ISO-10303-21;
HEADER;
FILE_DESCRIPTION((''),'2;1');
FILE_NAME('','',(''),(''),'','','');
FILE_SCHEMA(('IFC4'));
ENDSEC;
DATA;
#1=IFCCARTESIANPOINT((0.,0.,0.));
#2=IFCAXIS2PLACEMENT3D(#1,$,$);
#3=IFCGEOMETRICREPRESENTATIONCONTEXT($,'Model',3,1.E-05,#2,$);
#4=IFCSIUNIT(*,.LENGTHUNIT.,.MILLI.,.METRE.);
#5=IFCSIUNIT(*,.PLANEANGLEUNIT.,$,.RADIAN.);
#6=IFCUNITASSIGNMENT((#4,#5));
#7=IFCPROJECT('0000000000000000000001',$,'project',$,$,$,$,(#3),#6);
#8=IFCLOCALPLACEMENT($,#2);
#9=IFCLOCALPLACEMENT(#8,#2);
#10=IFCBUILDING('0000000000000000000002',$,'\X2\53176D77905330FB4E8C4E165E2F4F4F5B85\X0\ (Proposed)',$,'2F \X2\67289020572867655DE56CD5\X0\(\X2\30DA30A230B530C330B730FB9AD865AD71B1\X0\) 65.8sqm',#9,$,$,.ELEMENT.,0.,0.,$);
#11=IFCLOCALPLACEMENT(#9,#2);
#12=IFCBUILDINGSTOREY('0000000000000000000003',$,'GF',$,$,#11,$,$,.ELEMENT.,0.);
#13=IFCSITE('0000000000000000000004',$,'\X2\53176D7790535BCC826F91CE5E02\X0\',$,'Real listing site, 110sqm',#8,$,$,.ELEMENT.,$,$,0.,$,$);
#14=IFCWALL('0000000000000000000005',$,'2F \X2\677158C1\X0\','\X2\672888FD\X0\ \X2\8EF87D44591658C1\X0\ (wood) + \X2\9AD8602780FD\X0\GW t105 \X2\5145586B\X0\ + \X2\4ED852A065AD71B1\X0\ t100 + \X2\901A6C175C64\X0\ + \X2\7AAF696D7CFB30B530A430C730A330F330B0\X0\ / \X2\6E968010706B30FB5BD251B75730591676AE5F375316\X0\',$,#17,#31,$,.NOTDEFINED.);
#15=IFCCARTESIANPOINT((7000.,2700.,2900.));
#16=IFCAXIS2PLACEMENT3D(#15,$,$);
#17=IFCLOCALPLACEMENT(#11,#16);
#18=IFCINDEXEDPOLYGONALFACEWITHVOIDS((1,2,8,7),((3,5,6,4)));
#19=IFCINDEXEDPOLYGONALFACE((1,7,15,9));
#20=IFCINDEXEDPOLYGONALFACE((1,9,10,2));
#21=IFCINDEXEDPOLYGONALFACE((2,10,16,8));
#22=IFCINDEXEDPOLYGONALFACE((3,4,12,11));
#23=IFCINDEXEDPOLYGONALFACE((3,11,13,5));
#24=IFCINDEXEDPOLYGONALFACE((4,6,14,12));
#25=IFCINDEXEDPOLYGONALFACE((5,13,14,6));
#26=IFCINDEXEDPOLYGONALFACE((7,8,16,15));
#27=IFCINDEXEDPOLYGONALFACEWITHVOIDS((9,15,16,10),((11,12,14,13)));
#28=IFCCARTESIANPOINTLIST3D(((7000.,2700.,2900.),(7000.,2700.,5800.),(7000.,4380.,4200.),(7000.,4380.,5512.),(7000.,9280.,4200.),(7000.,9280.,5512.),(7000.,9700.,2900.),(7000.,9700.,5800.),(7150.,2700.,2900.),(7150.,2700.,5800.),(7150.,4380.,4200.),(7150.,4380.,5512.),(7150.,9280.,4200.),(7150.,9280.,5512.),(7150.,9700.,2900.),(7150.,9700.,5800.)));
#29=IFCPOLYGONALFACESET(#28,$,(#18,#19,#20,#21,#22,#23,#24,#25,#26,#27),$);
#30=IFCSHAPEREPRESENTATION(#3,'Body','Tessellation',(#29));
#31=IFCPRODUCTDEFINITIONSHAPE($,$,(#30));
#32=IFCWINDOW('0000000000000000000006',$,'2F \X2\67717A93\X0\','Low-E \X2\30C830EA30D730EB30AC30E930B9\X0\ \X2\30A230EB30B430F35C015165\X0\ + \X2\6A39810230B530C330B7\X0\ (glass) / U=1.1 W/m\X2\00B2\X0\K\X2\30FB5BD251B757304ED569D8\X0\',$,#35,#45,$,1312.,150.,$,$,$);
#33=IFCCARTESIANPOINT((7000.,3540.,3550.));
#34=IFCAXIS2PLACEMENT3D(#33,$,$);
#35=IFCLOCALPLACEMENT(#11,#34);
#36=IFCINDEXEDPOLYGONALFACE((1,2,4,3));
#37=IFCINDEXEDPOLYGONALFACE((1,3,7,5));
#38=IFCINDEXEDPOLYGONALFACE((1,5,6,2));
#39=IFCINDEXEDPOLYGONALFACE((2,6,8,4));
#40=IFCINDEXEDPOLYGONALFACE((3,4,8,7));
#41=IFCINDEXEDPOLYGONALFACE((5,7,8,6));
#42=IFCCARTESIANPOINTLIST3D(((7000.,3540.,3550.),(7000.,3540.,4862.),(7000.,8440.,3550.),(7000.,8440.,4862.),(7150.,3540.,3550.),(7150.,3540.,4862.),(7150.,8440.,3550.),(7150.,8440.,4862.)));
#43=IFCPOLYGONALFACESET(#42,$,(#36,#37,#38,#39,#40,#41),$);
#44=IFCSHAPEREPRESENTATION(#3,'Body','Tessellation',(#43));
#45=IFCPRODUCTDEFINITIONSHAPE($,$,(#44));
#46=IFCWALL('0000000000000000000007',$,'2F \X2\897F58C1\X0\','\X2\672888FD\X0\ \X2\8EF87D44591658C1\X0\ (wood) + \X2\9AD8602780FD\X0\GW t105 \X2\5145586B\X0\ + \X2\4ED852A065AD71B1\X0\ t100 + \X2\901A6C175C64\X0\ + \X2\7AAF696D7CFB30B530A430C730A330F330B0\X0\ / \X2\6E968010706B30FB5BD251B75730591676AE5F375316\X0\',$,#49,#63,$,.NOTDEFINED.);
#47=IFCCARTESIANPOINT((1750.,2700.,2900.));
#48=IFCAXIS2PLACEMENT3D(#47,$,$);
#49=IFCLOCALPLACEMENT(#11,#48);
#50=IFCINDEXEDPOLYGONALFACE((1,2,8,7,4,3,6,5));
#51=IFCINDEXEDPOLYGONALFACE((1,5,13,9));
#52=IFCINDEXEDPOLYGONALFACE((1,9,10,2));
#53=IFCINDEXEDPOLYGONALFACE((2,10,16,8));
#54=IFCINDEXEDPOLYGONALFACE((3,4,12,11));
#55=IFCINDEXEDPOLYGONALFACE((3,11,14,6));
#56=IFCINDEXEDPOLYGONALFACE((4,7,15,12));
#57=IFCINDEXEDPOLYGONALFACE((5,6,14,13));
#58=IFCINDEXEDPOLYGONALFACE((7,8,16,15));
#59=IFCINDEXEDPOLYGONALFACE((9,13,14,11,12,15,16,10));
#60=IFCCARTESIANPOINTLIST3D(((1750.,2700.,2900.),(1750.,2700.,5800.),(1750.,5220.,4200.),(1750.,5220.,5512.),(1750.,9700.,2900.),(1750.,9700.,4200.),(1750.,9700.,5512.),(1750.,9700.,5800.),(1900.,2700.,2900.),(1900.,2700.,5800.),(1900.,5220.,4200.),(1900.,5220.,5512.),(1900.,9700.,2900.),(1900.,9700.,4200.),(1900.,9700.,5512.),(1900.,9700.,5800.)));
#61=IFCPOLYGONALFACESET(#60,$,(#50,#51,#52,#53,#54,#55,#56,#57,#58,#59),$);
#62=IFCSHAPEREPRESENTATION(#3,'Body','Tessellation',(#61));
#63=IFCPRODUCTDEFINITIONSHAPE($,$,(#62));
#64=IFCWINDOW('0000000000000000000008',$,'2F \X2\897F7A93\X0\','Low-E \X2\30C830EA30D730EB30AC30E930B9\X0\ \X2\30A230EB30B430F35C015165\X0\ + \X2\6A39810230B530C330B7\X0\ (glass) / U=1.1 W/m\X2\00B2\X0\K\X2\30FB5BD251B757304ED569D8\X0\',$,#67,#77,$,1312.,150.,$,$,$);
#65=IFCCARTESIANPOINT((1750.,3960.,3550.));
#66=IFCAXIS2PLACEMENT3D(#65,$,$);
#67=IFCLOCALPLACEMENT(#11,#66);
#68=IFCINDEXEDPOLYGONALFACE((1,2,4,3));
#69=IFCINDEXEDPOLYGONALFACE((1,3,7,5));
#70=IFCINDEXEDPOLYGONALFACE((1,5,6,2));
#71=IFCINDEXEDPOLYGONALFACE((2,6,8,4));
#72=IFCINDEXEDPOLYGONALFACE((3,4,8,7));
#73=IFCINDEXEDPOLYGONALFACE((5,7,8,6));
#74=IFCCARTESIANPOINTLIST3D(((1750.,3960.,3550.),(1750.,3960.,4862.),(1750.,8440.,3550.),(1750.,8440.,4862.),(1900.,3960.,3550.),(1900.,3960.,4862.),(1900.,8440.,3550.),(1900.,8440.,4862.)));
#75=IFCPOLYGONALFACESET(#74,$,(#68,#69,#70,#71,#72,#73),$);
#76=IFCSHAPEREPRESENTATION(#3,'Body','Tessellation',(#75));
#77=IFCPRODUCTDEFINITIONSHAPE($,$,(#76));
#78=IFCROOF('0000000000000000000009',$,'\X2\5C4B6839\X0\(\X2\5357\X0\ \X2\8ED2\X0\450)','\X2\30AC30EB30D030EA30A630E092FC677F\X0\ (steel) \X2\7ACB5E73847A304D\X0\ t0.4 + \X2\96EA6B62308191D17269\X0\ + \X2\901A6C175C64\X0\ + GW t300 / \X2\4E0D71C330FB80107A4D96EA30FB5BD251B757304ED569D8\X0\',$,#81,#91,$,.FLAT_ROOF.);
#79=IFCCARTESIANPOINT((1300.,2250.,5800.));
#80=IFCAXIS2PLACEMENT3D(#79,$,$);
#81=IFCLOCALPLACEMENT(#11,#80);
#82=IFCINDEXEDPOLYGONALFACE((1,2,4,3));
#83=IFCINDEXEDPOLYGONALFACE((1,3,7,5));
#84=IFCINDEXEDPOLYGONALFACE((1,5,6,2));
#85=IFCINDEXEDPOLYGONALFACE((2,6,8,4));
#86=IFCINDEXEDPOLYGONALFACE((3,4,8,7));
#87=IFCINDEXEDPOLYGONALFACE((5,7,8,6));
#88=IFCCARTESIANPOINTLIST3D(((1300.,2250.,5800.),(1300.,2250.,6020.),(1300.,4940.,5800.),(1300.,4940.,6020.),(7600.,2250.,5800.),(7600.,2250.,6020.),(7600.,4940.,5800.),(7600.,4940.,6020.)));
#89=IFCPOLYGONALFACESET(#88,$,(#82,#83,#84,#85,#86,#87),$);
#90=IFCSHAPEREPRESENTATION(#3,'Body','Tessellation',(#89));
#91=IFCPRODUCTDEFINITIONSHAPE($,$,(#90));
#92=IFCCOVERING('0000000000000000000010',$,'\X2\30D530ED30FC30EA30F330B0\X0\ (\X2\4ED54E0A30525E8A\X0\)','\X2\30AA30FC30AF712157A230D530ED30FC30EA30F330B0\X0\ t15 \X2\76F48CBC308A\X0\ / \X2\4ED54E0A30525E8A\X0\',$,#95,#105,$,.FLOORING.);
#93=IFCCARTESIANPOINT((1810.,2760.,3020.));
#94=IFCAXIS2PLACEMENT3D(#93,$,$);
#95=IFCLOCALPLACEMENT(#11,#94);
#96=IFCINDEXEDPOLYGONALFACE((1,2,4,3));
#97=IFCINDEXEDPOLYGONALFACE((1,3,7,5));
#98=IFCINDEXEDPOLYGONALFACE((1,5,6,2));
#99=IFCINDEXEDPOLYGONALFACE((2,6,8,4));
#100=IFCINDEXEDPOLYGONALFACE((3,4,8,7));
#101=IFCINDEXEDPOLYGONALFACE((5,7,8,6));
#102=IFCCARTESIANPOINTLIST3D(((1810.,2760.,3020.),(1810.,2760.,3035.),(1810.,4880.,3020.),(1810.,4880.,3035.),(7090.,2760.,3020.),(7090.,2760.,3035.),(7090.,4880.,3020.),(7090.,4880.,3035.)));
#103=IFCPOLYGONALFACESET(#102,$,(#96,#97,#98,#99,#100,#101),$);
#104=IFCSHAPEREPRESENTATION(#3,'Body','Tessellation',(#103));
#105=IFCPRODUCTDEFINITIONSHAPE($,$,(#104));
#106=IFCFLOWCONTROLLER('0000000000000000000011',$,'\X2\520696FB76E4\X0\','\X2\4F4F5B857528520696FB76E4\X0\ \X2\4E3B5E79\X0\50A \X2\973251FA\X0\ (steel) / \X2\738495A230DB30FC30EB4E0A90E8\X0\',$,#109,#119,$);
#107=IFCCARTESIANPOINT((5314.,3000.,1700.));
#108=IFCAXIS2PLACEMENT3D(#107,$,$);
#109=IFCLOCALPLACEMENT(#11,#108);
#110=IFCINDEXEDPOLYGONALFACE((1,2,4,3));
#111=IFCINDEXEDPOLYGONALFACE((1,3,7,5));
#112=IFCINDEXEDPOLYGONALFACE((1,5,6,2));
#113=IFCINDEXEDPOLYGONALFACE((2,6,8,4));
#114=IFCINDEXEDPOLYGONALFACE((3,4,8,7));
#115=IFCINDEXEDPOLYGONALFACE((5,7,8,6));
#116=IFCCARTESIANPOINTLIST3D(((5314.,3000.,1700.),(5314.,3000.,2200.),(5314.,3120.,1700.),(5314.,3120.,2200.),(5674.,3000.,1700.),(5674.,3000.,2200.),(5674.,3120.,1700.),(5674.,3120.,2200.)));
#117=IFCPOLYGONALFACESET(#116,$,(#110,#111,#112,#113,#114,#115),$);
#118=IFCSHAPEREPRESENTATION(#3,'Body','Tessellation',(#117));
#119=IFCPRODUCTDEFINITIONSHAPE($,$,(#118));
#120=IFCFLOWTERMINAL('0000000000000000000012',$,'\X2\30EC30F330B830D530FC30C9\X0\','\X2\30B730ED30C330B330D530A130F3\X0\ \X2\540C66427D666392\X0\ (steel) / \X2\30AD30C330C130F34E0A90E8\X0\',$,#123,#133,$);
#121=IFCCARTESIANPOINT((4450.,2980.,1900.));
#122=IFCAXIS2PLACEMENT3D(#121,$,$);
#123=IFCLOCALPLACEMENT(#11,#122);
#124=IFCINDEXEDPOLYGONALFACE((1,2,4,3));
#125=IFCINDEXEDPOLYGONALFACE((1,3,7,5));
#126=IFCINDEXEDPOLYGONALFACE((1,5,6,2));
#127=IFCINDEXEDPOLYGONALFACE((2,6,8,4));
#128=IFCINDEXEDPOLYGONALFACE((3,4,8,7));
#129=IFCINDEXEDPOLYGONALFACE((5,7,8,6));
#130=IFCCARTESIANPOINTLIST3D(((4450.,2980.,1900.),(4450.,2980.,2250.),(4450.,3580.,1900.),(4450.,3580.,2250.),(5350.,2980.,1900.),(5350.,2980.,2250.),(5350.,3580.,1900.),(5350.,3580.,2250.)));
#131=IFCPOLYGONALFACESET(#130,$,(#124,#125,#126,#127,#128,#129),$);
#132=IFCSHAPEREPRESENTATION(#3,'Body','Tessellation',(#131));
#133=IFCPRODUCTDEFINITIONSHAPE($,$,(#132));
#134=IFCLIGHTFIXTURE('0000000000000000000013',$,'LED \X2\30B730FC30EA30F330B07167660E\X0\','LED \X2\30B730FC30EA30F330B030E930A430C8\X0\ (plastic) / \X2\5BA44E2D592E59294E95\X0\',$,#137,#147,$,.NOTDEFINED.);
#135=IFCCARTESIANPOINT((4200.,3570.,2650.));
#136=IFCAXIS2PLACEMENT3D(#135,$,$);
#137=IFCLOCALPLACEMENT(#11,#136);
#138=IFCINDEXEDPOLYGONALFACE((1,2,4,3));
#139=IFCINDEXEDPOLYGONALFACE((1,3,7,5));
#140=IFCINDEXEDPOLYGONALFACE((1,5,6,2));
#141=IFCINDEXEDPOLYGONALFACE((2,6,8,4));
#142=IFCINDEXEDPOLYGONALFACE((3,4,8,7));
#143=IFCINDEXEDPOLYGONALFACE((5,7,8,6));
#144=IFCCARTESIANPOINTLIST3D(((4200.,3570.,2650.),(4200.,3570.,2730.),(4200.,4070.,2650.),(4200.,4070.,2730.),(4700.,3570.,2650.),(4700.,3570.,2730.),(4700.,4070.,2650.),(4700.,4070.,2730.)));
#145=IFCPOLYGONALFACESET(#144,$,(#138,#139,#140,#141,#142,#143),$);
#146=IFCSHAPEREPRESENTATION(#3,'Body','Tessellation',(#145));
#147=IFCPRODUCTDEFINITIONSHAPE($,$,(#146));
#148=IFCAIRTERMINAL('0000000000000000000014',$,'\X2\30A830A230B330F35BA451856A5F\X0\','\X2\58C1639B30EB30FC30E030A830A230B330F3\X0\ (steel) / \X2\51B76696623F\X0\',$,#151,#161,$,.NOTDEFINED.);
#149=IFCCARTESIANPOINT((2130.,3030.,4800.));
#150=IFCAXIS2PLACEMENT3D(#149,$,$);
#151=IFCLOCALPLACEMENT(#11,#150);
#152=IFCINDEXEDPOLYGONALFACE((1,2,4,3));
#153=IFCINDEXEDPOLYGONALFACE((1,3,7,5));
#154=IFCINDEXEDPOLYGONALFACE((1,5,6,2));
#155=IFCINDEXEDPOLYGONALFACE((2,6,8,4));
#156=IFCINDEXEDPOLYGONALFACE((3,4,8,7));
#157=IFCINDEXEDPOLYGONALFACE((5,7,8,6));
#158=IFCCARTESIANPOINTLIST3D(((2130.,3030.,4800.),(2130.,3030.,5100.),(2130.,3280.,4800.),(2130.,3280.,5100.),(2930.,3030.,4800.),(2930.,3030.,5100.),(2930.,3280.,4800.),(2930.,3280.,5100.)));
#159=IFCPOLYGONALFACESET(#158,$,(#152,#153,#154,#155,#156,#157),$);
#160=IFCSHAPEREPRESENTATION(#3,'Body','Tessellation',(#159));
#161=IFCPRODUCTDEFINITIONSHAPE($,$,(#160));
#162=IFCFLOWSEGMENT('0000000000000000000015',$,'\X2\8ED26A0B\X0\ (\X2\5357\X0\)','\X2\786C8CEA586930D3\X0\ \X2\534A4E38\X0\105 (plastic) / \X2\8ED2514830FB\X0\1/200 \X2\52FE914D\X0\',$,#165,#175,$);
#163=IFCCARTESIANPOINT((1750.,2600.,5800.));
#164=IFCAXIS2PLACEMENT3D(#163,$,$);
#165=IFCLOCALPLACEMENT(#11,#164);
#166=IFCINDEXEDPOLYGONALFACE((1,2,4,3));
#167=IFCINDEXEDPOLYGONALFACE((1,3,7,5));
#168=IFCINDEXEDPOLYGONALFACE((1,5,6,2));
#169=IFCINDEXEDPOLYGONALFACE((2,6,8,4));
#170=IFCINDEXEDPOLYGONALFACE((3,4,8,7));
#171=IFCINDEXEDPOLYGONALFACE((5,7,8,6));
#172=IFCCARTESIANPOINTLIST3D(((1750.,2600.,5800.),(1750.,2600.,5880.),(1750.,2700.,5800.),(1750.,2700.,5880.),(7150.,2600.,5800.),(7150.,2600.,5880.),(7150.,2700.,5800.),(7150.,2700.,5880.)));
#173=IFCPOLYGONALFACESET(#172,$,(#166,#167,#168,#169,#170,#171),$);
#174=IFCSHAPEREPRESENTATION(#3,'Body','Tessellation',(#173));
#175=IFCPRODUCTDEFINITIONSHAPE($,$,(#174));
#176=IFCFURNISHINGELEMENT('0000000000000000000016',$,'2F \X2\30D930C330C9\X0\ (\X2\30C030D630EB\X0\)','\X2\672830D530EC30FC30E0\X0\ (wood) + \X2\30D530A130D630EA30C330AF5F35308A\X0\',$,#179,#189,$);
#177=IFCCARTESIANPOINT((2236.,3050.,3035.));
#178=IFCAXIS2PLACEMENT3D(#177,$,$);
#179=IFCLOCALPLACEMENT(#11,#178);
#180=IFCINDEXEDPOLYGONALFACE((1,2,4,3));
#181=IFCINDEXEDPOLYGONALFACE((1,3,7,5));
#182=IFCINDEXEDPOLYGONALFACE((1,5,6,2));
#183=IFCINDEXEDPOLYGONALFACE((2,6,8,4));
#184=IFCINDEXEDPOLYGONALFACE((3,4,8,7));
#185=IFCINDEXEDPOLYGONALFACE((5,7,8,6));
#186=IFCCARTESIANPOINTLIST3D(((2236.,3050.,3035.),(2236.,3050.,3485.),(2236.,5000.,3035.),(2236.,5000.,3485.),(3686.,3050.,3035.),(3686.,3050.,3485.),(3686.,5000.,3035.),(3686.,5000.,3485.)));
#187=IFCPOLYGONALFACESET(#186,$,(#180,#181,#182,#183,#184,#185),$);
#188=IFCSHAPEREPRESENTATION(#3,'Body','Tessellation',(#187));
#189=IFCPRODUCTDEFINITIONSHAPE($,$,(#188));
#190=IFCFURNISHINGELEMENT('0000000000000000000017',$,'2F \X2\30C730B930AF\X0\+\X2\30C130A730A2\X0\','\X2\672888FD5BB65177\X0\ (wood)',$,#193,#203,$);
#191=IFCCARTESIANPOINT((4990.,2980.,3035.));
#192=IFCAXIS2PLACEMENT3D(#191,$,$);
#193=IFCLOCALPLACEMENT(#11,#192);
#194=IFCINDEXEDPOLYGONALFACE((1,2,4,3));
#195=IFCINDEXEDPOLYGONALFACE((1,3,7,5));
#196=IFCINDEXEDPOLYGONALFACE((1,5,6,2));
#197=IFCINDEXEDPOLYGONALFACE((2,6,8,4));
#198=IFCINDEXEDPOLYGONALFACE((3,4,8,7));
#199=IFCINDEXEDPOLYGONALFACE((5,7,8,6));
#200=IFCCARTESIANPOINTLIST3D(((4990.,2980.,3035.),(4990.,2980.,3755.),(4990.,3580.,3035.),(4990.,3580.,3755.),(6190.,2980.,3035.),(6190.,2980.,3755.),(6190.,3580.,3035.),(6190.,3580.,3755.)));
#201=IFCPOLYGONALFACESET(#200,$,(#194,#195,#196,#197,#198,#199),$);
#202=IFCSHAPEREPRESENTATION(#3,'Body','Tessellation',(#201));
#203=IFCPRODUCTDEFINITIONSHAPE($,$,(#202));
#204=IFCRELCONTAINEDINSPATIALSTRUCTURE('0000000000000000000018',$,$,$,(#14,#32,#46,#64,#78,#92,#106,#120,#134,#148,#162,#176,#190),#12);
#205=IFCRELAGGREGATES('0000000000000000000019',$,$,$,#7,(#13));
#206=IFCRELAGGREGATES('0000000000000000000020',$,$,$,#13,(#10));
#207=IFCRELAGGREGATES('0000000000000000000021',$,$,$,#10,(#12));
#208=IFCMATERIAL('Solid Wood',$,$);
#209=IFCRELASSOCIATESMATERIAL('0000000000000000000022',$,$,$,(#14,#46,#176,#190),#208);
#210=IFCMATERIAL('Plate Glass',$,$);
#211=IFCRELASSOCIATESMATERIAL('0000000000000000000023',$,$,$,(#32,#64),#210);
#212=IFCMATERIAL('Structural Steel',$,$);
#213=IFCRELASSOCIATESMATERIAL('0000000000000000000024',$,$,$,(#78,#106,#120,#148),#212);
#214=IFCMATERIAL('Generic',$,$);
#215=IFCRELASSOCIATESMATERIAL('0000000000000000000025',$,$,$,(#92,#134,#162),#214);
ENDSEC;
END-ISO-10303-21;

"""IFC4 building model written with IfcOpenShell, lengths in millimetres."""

from ifc_helpers import new_model, si_unit, frame, frame_2d, origin, place, context, project, spatial, rectangle, extrude, material, element, fill, save


model = new_model("IFC4")

# Units and contexts
model_context = context("Model", 3, precision=1e-05, world=origin())
ifc_project = project(units=[si_unit("LENGTHUNIT", "METRE", prefix="MILLI"), si_unit("PLANEANGLEUNIT", "RADIAN")], contexts=[model_context])

# Site, building, storey
site_placement = place(None, origin())
site = spatial("IfcSite", under=ifc_project, at=site_placement, Name="北海道富良野市", ObjectType="Real listing site, 110sqm", CompositionType="ELEMENT", RefElevation=0.0)
building_placement = place(site_placement, origin())
building = spatial("IfcBuilding", under=site, at=building_placement, Name="北海道・二世帯住宅 (Proposed)", ObjectType="2F 木造在来工法(ペアサッシ・高断熱) 65.8sqm", CompositionType="ELEMENT", ElevationOfRefHeight=0.0, ElevationOfTerrain=0.0)
storey_placement = place(building_placement, origin())
storey = spatial("IfcBuildingStorey", under=building, at=storey_placement, Name="GF", CompositionType="ELEMENT", Elevation=0.0)

# Shared definitions
ifc_material_1 = material(Name="Solid Wood")

# Shared definitions
ifc_material_2 = material(Name="Plate Glass")

# Walls, openings, windows
wall_1_placement = place(storey_placement, frame((7000.0, 2700.0, 2900.0)))
wall_1 = element("IfcWall", 1, at=wall_1_placement, inside=storey, material=ifc_material_1, Name="2F 東壁", Description="木製 軸組外壁 (wood) + 高性能GW t105 充填 + 付加断熱 t100 + 通気層 + 窯業系サイディング / 準耐火・寒冷地外皮強化", PredefinedType="NOTDEFINED", context=model_context, shape_type="SweptSolid", body=[
    extrude(rectangle(XDim=150.0, YDim=7000.0, at=frame_2d((75.0, 3500.0))), frame((7000.0, 2700.0, 2900.0)), (0.0, 0.0, 1.0), 2900.0),
])
opening_1_placement = place(storey_placement, frame((7000.0, 3540.0, 3550.0)))
opening_1 = element("IfcOpeningElement", 2, at=opening_1_placement, cuts=wall_1, PredefinedType="NOTDEFINED", context=model_context, shape_type="SweptSolid", body=[
    extrude(rectangle(XDim=150.0, YDim=4900.0, at=frame_2d((75.0, 2450.0))), frame((7000.0, 3540.0, 3550.0)), (0.0, 0.0, 1.0), 1312.0),
])
window_1_placement = place(storey_placement, frame((7000.0, 3540.0, 3550.0)))
window_1 = element("IfcWindow", 3, at=window_1_placement, inside=storey, material=ifc_material_2, Name="2F 東窓", Description="Low-E トリプルガラス アルゴン封入 + 樹脂サッシ (glass) / U=1.1 W/m²K・寒冷地仕様", OverallHeight=1312.0, OverallWidth=150.0, context=model_context, shape_type="SweptSolid", body=[
    extrude(rectangle(XDim=150.0, YDim=4900.0, at=frame_2d((75.0, 2450.0))), frame((7000.0, 3540.0, 3550.0)), (0.0, 0.0, 1.0), 1312.0),
])
fill(opening_1, window_1)
wall_2_placement = place(storey_placement, frame((1750.0, 2700.0, 2900.0)))
wall_2 = element("IfcWall", 4, at=wall_2_placement, inside=storey, material=ifc_material_1, Name="2F 西壁", Description="木製 軸組外壁 (wood) + 高性能GW t105 充填 + 付加断熱 t100 + 通気層 + 窯業系サイディング / 準耐火・寒冷地外皮強化", PredefinedType="NOTDEFINED", context=model_context, shape_type="SweptSolid", body=[
    extrude(rectangle(XDim=150.0, YDim=7000.0, at=frame_2d((75.0, 3500.0))), frame((1750.0, 2700.0, 2900.0)), (0.0, 0.0, 1.0), 2900.0),
])
opening_2_placement = place(storey_placement, frame((1750.0, 3960.0, 3550.0)))
opening_2 = element("IfcOpeningElement", 5, at=opening_2_placement, cuts=wall_2, PredefinedType="NOTDEFINED", context=model_context, shape_type="SweptSolid", body=[
    extrude(rectangle(XDim=150.0, YDim=4480.0, at=frame_2d((75.0, 2240.0))), frame((1750.0, 3960.0, 3550.0)), (0.0, 0.0, 1.0), 1312.0),
])
window_2_placement = place(storey_placement, frame((1750.0, 3960.0, 3550.0)))
window_2 = element("IfcWindow", 6, at=window_2_placement, inside=storey, material=ifc_material_2, Name="2F 西窓", Description="Low-E トリプルガラス アルゴン封入 + 樹脂サッシ (glass) / U=1.1 W/m²K・寒冷地仕様", OverallHeight=1312.0, OverallWidth=150.0, context=model_context, shape_type="SweptSolid", body=[
    extrude(rectangle(XDim=150.0, YDim=4480.0, at=frame_2d((75.0, 2240.0))), frame((1750.0, 3960.0, 3550.0)), (0.0, 0.0, 1.0), 1312.0),
])
fill(opening_2, window_2)

# Roof
ifc_material_3 = material(Name="Structural Steel")
for number, where, name in (
    (7, (1300.0, 2250.0, 5800.0), "屋根(南 軒450)"),
):
    element("IfcRoof", number, at=place(storey_placement, frame(where)), inside=storey, material=ifc_material_3, Name=name, Description="ガルバリウム鋼板 (steel) 立平葺き t0.4 + 雪止め金物 + 通気層 + GW t300 / 不燃・耐積雪・寒冷地仕様", PredefinedType="FLAT_ROOF", context=model_context, shape_type="SweptSolid", body=[
        extrude(rectangle(XDim=6300.0, YDim=2690.0, at=frame_2d((3150.0, 1345.0))), frame((1300.0, 2250.0, 5800.0)), (0.0, 0.0, 1.0), 220.0),
    ])

# Covering
ifc_material_4 = material(Name="Generic")
covering_placement = place(storey_placement, frame((1810.0, 2760.0, 3020.0)))
element("IfcCovering", 8, at=covering_placement, inside=storey, material=ifc_material_4, Name="フローリング (仕上げ床)", Description="オーク無垢フローリング t15 直貼り / 仕上げ床", PredefinedType="FLOORING", context=model_context, shape_type="SweptSolid", body=[
    extrude(rectangle(XDim=5280.0, YDim=2120.0, at=frame_2d((2640.0, 1060.0))), frame((1810.0, 2760.0, 3020.0)), (0.0, 0.0, 1.0), 15.0),
])

# Flow controller
flow_controller_placement = place(storey_placement, frame((5314.0, 3000.0, 1700.0)))
element("IfcFlowController", 9, at=flow_controller_placement, inside=storey, material=ifc_material_3, Name="分電盤", Description="住宅用分電盤 主幹50A 露出 (steel) / 玄関ホール上部", context=model_context, shape_type="SweptSolid", body=[
    extrude(rectangle(XDim=360.0, YDim=120.0, at=frame_2d((180.0, 60.0))), frame((5314.0, 3000.0, 1700.0)), (0.0, 0.0, 1.0), 500.0),
])

# Flow terminal
flow_terminal_placement = place(storey_placement, frame((4450.0, 2980.0, 1900.0)))
element("IfcFlowTerminal", 10, at=flow_terminal_placement, inside=storey, material=ifc_material_3, Name="レンジフード", Description="シロッコファン 同時給排 (steel) / キッチン上部", context=model_context, shape_type="SweptSolid", body=[
    extrude(rectangle(XDim=900.0, YDim=600.0, at=frame_2d((450.0, 300.0))), frame((4450.0, 2980.0, 1900.0)), (0.0, 0.0, 1.0), 350.0),
])

# Light fixture
light_fixture_placement = place(storey_placement, frame((4200.0, 3570.0, 2650.0)))
element("IfcLightFixture", 11, at=light_fixture_placement, inside=storey, material=ifc_material_4, Name="LED シーリング照明", Description="LED シーリングライト (plastic) / 室中央天井", PredefinedType="NOTDEFINED", context=model_context, shape_type="SweptSolid", body=[
    extrude(rectangle(XDim=500.0, YDim=500.0, at=frame_2d((250.0, 250.0))), frame((4200.0, 3570.0, 2650.0)), (0.0, 0.0, 1.0), 80.0),
])

# Air terminal
air_terminal_placement = place(storey_placement, frame((2130.0, 3030.0, 4800.0)))
element("IfcAirTerminal", 12, at=air_terminal_placement, inside=storey, material=ifc_material_3, Name="エアコン室内機", Description="壁掛ルームエアコン (steel) / 冷暖房", PredefinedType="NOTDEFINED", context=model_context, shape_type="SweptSolid", body=[
    extrude(rectangle(XDim=800.0, YDim=250.0, at=frame_2d((400.0, 125.0))), frame((2130.0, 3030.0, 4800.0)), (0.0, 0.0, 1.0), 300.0),
])

# Flow segment
flow_segment_placement = place(storey_placement, frame((1750.0, 2600.0, 5800.0)))
element("IfcFlowSegment", 13, at=flow_segment_placement, inside=storey, material=ifc_material_4, Name="軒樋 (南)", Description="硬質塩ビ 半丸105 (plastic) / 軒先・1/200 勾配", context=model_context, shape_type="SweptSolid", body=[
    extrude(rectangle(XDim=5400.0, YDim=100.0, at=frame_2d((2700.0, 50.0))), frame((1750.0, 2600.0, 5800.0)), (0.0, 0.0, 1.0), 80.0),
])

# Furnishing elements
furnishing_1_placement = place(storey_placement, frame((2236.0, 3050.0, 3035.0)))
element("IfcFurnishingElement", 14, at=furnishing_1_placement, inside=storey, material=ifc_material_1, Name="2F ベッド (ダブル)", Description="木フレーム (wood) + ファブリック張り", context=model_context, shape_type="SweptSolid", body=[
    extrude(rectangle(XDim=1450.0, YDim=1950.0, at=frame_2d((725.0, 975.0))), frame((2236.0, 3050.0, 3035.0)), (0.0, 0.0, 1.0), 450.0),
])
furnishing_2_placement = place(storey_placement, frame((4990.0, 2980.0, 3035.0)))
element("IfcFurnishingElement", 15, at=furnishing_2_placement, inside=storey, material=ifc_material_1, Name="2F デスク+チェア", Description="木製家具 (wood)", context=model_context, shape_type="SweptSolid", body=[
    extrude(rectangle(XDim=1200.0, YDim=600.0, at=frame_2d((600.0, 300.0))), frame((4990.0, 2980.0, 3035.0)), (0.0, 0.0, 1.0), 720.0),
])

save(model, "model.ifc")
